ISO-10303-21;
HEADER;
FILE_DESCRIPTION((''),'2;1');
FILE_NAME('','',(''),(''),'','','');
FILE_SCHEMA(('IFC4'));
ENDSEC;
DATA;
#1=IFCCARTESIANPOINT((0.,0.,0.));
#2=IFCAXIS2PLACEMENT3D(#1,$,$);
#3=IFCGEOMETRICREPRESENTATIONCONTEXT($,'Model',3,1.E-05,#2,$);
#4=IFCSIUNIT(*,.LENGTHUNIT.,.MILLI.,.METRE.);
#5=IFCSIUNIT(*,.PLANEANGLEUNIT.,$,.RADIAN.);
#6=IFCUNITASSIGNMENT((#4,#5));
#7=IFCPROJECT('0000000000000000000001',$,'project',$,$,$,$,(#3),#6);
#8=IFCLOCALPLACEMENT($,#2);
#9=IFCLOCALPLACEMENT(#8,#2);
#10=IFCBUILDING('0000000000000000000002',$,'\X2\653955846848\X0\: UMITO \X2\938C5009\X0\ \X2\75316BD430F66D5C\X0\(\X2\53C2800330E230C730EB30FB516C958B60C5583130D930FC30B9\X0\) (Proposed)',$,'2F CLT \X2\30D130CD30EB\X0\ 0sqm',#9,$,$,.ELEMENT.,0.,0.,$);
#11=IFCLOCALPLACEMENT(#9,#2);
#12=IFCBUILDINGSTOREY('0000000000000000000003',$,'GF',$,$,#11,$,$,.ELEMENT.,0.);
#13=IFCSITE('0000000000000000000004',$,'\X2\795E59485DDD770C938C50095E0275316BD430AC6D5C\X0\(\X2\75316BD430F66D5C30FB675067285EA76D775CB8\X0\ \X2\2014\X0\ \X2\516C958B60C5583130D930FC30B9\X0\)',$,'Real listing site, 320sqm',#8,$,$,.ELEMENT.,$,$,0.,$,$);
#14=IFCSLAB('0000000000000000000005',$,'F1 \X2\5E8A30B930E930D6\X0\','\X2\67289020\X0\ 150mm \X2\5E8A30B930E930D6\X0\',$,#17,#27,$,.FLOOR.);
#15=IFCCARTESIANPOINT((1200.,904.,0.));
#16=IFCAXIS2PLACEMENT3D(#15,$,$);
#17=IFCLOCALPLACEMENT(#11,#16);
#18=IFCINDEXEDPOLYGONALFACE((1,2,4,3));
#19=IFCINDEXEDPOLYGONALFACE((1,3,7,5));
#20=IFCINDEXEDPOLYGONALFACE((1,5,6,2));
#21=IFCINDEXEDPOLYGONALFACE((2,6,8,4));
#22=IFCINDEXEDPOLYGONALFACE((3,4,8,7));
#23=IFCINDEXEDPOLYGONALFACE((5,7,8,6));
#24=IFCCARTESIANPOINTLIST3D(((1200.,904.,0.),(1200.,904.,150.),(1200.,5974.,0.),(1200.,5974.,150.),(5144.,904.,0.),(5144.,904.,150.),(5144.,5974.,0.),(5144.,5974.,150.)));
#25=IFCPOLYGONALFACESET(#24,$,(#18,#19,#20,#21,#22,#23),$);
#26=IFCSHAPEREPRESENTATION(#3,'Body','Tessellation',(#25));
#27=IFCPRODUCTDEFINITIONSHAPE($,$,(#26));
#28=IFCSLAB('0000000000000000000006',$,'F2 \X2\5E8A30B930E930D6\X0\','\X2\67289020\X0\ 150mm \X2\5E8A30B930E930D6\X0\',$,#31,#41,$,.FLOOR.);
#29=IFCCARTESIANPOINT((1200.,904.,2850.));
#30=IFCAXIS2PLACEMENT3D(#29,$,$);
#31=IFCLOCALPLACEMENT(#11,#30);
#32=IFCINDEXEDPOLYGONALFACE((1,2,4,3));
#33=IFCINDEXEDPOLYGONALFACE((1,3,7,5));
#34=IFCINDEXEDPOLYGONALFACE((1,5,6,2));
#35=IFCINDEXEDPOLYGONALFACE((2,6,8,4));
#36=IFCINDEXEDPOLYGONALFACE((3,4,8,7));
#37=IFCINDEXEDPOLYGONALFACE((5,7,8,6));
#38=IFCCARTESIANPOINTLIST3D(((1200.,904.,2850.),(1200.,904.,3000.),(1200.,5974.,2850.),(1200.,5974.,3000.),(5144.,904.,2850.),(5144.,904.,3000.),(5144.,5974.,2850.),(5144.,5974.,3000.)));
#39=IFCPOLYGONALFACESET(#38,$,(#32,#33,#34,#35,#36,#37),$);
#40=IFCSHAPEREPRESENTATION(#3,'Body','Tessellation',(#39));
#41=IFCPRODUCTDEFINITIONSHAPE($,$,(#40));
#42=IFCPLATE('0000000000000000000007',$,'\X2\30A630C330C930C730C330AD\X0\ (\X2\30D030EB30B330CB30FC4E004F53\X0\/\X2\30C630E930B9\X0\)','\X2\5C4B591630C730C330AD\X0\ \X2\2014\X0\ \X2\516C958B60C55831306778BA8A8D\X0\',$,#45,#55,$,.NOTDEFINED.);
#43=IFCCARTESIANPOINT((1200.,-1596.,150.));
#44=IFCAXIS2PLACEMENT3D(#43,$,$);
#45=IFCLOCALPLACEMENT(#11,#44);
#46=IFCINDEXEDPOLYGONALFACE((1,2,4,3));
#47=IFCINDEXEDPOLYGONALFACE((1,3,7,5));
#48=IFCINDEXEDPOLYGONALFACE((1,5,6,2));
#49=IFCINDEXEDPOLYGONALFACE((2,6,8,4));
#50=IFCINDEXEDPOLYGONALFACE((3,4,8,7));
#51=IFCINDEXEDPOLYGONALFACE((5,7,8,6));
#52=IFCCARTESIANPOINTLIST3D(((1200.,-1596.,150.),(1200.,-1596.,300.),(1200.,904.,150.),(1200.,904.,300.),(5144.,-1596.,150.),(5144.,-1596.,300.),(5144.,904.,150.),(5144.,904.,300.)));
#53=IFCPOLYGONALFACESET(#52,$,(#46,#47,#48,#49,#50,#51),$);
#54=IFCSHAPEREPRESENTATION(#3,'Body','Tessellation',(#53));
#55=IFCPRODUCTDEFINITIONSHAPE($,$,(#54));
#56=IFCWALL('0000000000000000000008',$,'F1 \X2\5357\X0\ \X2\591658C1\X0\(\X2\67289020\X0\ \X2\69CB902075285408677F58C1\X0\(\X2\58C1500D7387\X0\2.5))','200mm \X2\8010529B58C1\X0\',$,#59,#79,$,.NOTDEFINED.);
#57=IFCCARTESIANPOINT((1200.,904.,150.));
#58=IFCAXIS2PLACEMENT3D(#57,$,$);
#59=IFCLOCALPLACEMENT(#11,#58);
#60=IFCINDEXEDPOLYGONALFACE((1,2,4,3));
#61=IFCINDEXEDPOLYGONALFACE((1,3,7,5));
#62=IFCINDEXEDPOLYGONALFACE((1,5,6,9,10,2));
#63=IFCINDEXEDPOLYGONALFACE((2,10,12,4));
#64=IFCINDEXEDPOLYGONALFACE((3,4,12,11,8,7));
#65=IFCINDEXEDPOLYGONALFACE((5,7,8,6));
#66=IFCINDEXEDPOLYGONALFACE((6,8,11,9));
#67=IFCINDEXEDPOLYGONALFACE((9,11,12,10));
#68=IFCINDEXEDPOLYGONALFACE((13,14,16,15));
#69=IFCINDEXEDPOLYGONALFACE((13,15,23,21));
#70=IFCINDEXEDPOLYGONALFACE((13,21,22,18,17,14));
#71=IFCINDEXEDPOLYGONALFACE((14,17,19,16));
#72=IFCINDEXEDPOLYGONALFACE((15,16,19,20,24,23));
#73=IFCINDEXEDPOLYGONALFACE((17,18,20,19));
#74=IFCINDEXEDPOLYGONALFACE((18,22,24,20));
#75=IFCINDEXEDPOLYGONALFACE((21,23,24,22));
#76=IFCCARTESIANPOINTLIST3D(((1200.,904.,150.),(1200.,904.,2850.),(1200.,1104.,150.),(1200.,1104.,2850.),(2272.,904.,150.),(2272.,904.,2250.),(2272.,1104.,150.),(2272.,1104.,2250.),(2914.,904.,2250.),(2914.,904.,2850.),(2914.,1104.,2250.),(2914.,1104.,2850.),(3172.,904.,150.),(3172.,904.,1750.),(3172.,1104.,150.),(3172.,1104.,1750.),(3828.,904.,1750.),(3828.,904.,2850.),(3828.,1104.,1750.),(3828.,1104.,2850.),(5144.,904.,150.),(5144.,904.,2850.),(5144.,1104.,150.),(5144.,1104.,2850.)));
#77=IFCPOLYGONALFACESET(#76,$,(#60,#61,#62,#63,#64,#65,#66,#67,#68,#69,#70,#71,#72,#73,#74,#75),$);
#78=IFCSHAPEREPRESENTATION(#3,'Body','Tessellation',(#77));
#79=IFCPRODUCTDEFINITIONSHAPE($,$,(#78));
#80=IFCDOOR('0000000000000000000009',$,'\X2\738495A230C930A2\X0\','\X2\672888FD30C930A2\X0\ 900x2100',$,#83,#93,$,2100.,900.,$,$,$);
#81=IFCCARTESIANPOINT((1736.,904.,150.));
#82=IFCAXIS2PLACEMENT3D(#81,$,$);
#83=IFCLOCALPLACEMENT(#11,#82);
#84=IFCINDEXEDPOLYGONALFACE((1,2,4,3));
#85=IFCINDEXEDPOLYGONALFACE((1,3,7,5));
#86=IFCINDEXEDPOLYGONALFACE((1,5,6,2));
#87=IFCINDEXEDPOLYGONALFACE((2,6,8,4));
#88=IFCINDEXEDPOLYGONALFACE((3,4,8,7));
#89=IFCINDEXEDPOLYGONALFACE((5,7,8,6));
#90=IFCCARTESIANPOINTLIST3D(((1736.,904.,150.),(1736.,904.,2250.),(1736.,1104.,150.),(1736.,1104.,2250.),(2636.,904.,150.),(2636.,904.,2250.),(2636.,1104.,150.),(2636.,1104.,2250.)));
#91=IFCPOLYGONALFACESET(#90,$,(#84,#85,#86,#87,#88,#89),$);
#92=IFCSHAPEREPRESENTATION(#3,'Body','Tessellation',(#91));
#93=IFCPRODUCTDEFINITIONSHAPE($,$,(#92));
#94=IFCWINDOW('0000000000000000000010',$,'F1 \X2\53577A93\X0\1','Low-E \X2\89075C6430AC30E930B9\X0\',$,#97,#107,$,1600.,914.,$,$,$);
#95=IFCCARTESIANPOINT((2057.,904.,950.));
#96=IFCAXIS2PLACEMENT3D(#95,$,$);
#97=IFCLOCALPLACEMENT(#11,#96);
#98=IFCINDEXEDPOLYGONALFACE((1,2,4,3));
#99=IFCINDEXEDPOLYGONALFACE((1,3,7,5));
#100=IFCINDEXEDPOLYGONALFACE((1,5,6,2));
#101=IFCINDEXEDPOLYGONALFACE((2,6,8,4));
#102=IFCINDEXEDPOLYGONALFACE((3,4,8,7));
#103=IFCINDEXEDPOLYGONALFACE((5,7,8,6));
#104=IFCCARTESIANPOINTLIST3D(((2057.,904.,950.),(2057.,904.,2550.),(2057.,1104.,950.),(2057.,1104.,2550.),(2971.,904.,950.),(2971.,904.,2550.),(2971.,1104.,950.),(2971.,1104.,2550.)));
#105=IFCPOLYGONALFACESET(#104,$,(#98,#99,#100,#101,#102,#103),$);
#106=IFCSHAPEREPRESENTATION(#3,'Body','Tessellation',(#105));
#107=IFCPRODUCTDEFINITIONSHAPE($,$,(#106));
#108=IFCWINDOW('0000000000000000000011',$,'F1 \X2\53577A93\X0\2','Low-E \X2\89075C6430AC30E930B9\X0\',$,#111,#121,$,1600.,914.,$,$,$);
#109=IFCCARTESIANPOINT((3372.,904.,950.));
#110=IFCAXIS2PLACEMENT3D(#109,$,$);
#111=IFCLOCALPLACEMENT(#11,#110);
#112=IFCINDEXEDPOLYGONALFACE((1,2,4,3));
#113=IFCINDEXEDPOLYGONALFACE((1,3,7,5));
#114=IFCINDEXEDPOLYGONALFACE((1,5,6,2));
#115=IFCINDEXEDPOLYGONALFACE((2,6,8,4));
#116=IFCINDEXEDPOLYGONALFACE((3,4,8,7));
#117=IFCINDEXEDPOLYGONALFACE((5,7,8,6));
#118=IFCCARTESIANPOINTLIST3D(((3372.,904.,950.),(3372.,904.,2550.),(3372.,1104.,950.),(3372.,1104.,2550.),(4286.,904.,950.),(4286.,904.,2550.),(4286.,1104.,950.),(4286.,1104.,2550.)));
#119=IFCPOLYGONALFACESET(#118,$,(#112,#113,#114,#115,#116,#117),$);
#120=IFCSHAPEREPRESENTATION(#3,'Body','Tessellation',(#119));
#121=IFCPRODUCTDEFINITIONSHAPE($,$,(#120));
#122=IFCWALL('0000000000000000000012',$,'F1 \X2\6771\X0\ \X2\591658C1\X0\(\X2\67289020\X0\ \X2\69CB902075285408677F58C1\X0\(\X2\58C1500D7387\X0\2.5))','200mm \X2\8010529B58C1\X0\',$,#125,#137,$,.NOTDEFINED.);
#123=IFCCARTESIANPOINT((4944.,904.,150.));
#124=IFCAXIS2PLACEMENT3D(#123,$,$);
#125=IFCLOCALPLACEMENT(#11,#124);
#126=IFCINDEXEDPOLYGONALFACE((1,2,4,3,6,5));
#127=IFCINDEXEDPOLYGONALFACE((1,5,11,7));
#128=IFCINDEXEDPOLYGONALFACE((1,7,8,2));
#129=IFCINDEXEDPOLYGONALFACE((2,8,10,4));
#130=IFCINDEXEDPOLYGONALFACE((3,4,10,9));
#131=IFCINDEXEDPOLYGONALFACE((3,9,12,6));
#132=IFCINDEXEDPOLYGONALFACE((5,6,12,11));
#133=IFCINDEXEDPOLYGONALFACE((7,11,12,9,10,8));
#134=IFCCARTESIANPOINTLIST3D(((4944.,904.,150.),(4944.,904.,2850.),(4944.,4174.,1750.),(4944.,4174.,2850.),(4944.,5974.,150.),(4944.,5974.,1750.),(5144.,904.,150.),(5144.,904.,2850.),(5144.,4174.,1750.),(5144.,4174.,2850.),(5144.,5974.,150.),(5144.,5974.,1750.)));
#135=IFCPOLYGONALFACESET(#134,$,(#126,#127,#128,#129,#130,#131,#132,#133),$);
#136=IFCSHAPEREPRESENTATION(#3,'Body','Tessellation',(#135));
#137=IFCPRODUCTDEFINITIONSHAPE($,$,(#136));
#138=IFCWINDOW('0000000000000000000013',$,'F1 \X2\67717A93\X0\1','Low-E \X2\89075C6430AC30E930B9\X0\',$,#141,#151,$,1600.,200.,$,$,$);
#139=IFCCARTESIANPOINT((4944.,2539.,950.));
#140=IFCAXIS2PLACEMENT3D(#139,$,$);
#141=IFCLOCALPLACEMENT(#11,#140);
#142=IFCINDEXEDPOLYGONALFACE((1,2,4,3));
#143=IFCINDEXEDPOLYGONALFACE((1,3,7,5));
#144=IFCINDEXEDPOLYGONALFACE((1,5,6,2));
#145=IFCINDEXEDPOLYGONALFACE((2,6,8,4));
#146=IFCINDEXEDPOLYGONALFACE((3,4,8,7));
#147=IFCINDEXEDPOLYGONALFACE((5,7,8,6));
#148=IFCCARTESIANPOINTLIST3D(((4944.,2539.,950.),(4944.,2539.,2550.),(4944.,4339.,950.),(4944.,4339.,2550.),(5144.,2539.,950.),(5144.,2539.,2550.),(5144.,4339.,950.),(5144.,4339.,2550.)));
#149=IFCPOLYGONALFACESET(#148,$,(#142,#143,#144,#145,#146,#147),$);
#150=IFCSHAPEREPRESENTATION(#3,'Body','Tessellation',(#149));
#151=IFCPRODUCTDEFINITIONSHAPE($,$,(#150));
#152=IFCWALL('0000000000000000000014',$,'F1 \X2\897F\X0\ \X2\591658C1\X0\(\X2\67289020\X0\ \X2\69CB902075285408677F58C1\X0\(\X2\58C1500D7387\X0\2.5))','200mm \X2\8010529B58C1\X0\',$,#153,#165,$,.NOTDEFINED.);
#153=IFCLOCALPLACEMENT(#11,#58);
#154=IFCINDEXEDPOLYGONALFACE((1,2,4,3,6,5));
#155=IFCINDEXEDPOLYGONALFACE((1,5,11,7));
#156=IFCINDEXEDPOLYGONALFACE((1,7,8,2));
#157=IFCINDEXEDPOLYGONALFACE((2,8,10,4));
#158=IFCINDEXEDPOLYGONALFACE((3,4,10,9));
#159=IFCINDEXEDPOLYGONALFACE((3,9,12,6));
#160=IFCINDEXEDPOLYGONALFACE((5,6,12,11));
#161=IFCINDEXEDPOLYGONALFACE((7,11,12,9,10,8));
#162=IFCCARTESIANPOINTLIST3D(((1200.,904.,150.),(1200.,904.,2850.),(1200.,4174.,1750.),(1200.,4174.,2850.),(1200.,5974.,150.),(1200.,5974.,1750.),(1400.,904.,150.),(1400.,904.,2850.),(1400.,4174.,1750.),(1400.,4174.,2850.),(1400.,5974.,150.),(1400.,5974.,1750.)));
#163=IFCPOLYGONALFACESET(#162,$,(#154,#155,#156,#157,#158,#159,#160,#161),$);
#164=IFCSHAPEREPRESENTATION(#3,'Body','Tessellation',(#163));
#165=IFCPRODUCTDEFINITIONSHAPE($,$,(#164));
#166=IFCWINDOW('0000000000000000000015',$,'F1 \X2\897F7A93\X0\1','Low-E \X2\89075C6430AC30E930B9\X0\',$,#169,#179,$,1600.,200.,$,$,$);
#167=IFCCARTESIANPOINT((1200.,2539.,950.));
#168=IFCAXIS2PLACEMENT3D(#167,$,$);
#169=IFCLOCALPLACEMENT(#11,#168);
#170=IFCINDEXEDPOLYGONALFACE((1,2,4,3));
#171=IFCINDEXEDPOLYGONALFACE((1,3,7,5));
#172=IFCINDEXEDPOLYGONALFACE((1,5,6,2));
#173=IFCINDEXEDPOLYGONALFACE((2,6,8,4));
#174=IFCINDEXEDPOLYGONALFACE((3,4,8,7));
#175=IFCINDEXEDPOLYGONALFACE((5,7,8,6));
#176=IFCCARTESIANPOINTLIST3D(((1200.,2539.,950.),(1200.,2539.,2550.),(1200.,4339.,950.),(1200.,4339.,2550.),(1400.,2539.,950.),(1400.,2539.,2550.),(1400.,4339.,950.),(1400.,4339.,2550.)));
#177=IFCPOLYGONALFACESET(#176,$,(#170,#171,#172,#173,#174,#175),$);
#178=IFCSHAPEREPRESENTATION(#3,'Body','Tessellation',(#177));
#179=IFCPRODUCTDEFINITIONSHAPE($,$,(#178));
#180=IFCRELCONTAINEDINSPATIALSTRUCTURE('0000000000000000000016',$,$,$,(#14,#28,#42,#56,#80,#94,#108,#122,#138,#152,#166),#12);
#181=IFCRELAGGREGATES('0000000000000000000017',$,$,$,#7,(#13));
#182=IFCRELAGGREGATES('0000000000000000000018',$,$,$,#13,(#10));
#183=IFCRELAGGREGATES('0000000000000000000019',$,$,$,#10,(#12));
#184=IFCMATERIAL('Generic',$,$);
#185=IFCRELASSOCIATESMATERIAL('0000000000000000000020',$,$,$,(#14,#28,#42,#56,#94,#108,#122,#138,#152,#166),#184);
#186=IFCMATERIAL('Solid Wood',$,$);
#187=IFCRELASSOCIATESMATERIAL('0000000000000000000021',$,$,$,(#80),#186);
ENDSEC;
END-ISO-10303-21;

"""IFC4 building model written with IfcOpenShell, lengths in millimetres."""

from ifc_helpers import new_model, si_unit, frame, frame_2d, origin, place, context, project, spatial, rectangle, extrude, material, element, fill, save


model = new_model("IFC4")

# Units and contexts
model_context = context("Model", 3, precision=1e-05, world=origin())
ifc_project = project(units=[si_unit("LENGTHUNIT", "METRE", prefix="MILLI"), si_unit("PLANEANGLEUNIT", "RADIAN")], contexts=[model_context])

# Site, building, storey
site_placement = place(None, origin())
site = spatial("IfcSite", under=ifc_project, at=site_placement, Name="神奈川県鎌倉市由比ガ浜(由比ヶ浜・材木座海岸 — 公開情報ベース)", ObjectType="Real listing site, 320sqm", CompositionType="ELEMENT", RefElevation=0.0)
building_placement = place(site_placement, origin())
building = spatial("IfcBuilding", under=site, at=building_placement, Name="改善案: UMITO 鎌倉 由比ヶ浜(参考モデル・公開情報ベース) (Proposed)", ObjectType="2F CLT パネル 0sqm", CompositionType="ELEMENT", ElevationOfRefHeight=0.0, ElevationOfTerrain=0.0)
storey_placement = place(building_placement, origin())
storey = spatial("IfcBuildingStorey", under=building, at=storey_placement, Name="GF", CompositionType="ELEMENT", Elevation=0.0)

# Slabs
ifc_material_1 = material(Name="Generic")
slab_1_placement = place(storey_placement, frame((1200.0, 904.0, 0.0)))
element("IfcSlab", 1, at=slab_1_placement, inside=storey, material=ifc_material_1, Name="F1 床スラブ", Description="木造 150mm 床スラブ", PredefinedType="FLOOR", context=model_context, shape_type="SweptSolid", body=[
    extrude(rectangle(XDim=3944.0, YDim=5070.0, at=frame_2d((1972.0, 2535.0))), frame((1200.0, 904.0, 0.0)), (0.0, 0.0, 1.0), 150.0),
])
slab_2_placement = place(storey_placement, frame((1200.0, 904.0, 2850.0)))
element("IfcSlab", 2, at=slab_2_placement, inside=storey, material=ifc_material_1, Name="F2 床スラブ", Description="木造 150mm 床スラブ", PredefinedType="FLOOR", context=model_context, shape_type="SweptSolid", body=[
    extrude(rectangle(XDim=3944.0, YDim=5070.0, at=frame_2d((1972.0, 2535.0))), frame((1200.0, 904.0, 2850.0)), (0.0, 0.0, 1.0), 150.0),
])

# Plate
plate_placement = place(storey_placement, frame((1200.0, -1596.0, 150.0)))
element("IfcPlate", 3, at=plate_placement, inside=storey, material=ifc_material_1, Name="ウッドデッキ (バルコニー一体/テラス)", Description="屋外デッキ — 公開情報で確認", PredefinedType="NOTDEFINED", context=model_context, shape_type="SweptSolid", body=[
    extrude(rectangle(XDim=3944.0, YDim=2500.0, at=frame_2d((1972.0, 1250.0))), frame((1200.0, -1596.0, 150.0)), (0.0, 0.0, 1.0), 150.0),
])

# Wall, openings, door, windows
wall_1_placement = place(storey_placement, frame((1200.0, 904.0, 150.0)))
wall_1 = element("IfcWall", 4, at=wall_1_placement, inside=storey, material=ifc_material_1, Name="F1 南 外壁(木造 構造用合板壁(壁倍率2.5))", Description="200mm 耐力壁", PredefinedType="NOTDEFINED", context=model_context, shape_type="SweptSolid", body=[
    extrude(rectangle(XDim=3944.0, YDim=200.0, at=frame_2d((1972.0, 100.0))), frame((1200.0, 904.0, 150.0)), (0.0, 0.0, 1.0), 2700.0),
])
opening_1_placement = place(storey_placement, frame((1736.0, 904.0, 150.0)))
opening_1 = element("IfcOpeningElement", 5, at=opening_1_placement, cuts=wall_1, PredefinedType="NOTDEFINED", context=model_context, shape_type="SweptSolid", body=[
    extrude(rectangle(XDim=900.0, YDim=200.0, at=frame_2d((450.0, 100.0))), frame((1736.0, 904.0, 150.0)), (0.0, 0.0, 1.0), 2100.0),
])
opening_2_placement = place(storey_placement, frame((2057.0, 904.0, 950.0)))
opening_2 = element("IfcOpeningElement", 6, at=opening_2_placement, cuts=wall_1, PredefinedType="NOTDEFINED", context=model_context, shape_type="SweptSolid", body=[
    extrude(rectangle(XDim=914.0, YDim=200.0, at=frame_2d((457.0, 100.0))), frame((2057.0, 904.0, 950.0)), (0.0, 0.0, 1.0), 1600.0),
])
opening_3_placement = place(storey_placement, frame((3372.0, 904.0, 950.0)))
opening_3 = element("IfcOpeningElement", 7, at=opening_3_placement, cuts=wall_1, PredefinedType="NOTDEFINED", context=model_context, shape_type="SweptSolid", body=[
    extrude(rectangle(XDim=914.0, YDim=200.0, at=frame_2d((457.0, 100.0))), frame((3372.0, 904.0, 950.0)), (0.0, 0.0, 1.0), 1600.0),
])
ifc_material_2 = material(Name="Solid Wood")
door_placement = place(storey_placement, frame((1736.0, 904.0, 150.0)))
door = element("IfcDoor", 8, at=door_placement, inside=storey, material=ifc_material_2, Name="玄関ドア", Description="木製ドア 900x2100", OverallHeight=2100.0, OverallWidth=900.0, context=model_context, shape_type="SweptSolid", body=[
    extrude(rectangle(XDim=900.0, YDim=200.0, at=frame_2d((450.0, 100.0))), frame((1736.0, 904.0, 150.0)), (0.0, 0.0, 1.0), 2100.0),
])
fill(opening_1, door)
window_1_placement = place(storey_placement, frame((2057.0, 904.0, 950.0)))
window_1 = element("IfcWindow", 9, at=window_1_placement, inside=storey, material=ifc_material_1, Name="F1 南窓1", Description="Low-E 複層ガラス", OverallHeight=1600.0, OverallWidth=914.0, context=model_context, shape_type="SweptSolid", body=[
    extrude(rectangle(XDim=914.0, YDim=200.0, at=frame_2d((457.0, 100.0))), frame((2057.0, 904.0, 950.0)), (0.0, 0.0, 1.0), 1600.0),
])
fill(opening_2, window_1)
window_2_placement = place(storey_placement, frame((3372.0, 904.0, 950.0)))
window_2 = element("IfcWindow", 10, at=window_2_placement, inside=storey, material=ifc_material_1, Name="F1 南窓2", Description="Low-E 複層ガラス", OverallHeight=1600.0, OverallWidth=914.0, context=model_context, shape_type="SweptSolid", body=[
    extrude(rectangle(XDim=914.0, YDim=200.0, at=frame_2d((457.0, 100.0))), frame((3372.0, 904.0, 950.0)), (0.0, 0.0, 1.0), 1600.0),
])
fill(opening_3, window_2)

# Walls, openings, windows
wall_2_placement = place(storey_placement, frame((4944.0, 904.0, 150.0)))
wall_2 = element("IfcWall", 11, at=wall_2_placement, inside=storey, material=ifc_material_1, Name="F1 東 外壁(木造 構造用合板壁(壁倍率2.5))", Description="200mm 耐力壁", PredefinedType="NOTDEFINED", context=model_context, shape_type="SweptSolid", body=[
    extrude(rectangle(XDim=200.0, YDim=5070.0, at=frame_2d((100.0, 2535.0))), frame((4944.0, 904.0, 150.0)), (0.0, 0.0, 1.0), 2700.0),
])
opening_4_placement = place(storey_placement, frame((4944.0, 2539.0, 950.0)))
opening_4 = element("IfcOpeningElement", 12, at=opening_4_placement, cuts=wall_2, PredefinedType="NOTDEFINED", context=model_context, shape_type="SweptSolid", body=[
    extrude(rectangle(XDim=200.0, YDim=1800.0, at=frame_2d((100.0, 900.0))), frame((4944.0, 2539.0, 950.0)), (0.0, 0.0, 1.0), 1600.0),
])
window_3_placement = place(storey_placement, frame((4944.0, 2539.0, 950.0)))
window_3 = element("IfcWindow", 13, at=window_3_placement, inside=storey, material=ifc_material_1, Name="F1 東窓1", Description="Low-E 複層ガラス", OverallHeight=1600.0, OverallWidth=200.0, context=model_context, shape_type="SweptSolid", body=[
    extrude(rectangle(XDim=200.0, YDim=1800.0, at=frame_2d((100.0, 900.0))), frame((4944.0, 2539.0, 950.0)), (0.0, 0.0, 1.0), 1600.0),
])
fill(opening_4, window_3)
wall_3_placement = place(storey_placement, frame((1200.0, 904.0, 150.0)))
wall_3 = element("IfcWall", 14, at=wall_3_placement, inside=storey, material=ifc_material_1, Name="F1 西 外壁(木造 構造用合板壁(壁倍率2.5))", Description="200mm 耐力壁", PredefinedType="NOTDEFINED", context=model_context, shape_type="SweptSolid", body=[
    extrude(rectangle(XDim=200.0, YDim=5070.0, at=frame_2d((100.0, 2535.0))), frame((1200.0, 904.0, 150.0)), (0.0, 0.0, 1.0), 2700.0),
])
opening_5_placement = place(storey_placement, frame((1200.0, 2539.0, 950.0)))
opening_5 = element("IfcOpeningElement", 15, at=opening_5_placement, cuts=wall_3, PredefinedType="NOTDEFINED", context=model_context, shape_type="SweptSolid", body=[
    extrude(rectangle(XDim=200.0, YDim=1800.0, at=frame_2d((100.0, 900.0))), frame((1200.0, 2539.0, 950.0)), (0.0, 0.0, 1.0), 1600.0),
])
window_4_placement = place(storey_placement, frame((1200.0, 2539.0, 950.0)))
window_4 = element("IfcWindow", 16, at=window_4_placement, inside=storey, material=ifc_material_1, Name="F1 西窓1", Description="Low-E 複層ガラス", OverallHeight=1600.0, OverallWidth=200.0, context=model_context, shape_type="SweptSolid", body=[
    extrude(rectangle(XDim=200.0, YDim=1800.0, at=frame_2d((100.0, 900.0))), frame((1200.0, 2539.0, 950.0)), (0.0, 0.0, 1.0), 1600.0),
])
fill(opening_5, window_4)

save(model, "model.ifc")
